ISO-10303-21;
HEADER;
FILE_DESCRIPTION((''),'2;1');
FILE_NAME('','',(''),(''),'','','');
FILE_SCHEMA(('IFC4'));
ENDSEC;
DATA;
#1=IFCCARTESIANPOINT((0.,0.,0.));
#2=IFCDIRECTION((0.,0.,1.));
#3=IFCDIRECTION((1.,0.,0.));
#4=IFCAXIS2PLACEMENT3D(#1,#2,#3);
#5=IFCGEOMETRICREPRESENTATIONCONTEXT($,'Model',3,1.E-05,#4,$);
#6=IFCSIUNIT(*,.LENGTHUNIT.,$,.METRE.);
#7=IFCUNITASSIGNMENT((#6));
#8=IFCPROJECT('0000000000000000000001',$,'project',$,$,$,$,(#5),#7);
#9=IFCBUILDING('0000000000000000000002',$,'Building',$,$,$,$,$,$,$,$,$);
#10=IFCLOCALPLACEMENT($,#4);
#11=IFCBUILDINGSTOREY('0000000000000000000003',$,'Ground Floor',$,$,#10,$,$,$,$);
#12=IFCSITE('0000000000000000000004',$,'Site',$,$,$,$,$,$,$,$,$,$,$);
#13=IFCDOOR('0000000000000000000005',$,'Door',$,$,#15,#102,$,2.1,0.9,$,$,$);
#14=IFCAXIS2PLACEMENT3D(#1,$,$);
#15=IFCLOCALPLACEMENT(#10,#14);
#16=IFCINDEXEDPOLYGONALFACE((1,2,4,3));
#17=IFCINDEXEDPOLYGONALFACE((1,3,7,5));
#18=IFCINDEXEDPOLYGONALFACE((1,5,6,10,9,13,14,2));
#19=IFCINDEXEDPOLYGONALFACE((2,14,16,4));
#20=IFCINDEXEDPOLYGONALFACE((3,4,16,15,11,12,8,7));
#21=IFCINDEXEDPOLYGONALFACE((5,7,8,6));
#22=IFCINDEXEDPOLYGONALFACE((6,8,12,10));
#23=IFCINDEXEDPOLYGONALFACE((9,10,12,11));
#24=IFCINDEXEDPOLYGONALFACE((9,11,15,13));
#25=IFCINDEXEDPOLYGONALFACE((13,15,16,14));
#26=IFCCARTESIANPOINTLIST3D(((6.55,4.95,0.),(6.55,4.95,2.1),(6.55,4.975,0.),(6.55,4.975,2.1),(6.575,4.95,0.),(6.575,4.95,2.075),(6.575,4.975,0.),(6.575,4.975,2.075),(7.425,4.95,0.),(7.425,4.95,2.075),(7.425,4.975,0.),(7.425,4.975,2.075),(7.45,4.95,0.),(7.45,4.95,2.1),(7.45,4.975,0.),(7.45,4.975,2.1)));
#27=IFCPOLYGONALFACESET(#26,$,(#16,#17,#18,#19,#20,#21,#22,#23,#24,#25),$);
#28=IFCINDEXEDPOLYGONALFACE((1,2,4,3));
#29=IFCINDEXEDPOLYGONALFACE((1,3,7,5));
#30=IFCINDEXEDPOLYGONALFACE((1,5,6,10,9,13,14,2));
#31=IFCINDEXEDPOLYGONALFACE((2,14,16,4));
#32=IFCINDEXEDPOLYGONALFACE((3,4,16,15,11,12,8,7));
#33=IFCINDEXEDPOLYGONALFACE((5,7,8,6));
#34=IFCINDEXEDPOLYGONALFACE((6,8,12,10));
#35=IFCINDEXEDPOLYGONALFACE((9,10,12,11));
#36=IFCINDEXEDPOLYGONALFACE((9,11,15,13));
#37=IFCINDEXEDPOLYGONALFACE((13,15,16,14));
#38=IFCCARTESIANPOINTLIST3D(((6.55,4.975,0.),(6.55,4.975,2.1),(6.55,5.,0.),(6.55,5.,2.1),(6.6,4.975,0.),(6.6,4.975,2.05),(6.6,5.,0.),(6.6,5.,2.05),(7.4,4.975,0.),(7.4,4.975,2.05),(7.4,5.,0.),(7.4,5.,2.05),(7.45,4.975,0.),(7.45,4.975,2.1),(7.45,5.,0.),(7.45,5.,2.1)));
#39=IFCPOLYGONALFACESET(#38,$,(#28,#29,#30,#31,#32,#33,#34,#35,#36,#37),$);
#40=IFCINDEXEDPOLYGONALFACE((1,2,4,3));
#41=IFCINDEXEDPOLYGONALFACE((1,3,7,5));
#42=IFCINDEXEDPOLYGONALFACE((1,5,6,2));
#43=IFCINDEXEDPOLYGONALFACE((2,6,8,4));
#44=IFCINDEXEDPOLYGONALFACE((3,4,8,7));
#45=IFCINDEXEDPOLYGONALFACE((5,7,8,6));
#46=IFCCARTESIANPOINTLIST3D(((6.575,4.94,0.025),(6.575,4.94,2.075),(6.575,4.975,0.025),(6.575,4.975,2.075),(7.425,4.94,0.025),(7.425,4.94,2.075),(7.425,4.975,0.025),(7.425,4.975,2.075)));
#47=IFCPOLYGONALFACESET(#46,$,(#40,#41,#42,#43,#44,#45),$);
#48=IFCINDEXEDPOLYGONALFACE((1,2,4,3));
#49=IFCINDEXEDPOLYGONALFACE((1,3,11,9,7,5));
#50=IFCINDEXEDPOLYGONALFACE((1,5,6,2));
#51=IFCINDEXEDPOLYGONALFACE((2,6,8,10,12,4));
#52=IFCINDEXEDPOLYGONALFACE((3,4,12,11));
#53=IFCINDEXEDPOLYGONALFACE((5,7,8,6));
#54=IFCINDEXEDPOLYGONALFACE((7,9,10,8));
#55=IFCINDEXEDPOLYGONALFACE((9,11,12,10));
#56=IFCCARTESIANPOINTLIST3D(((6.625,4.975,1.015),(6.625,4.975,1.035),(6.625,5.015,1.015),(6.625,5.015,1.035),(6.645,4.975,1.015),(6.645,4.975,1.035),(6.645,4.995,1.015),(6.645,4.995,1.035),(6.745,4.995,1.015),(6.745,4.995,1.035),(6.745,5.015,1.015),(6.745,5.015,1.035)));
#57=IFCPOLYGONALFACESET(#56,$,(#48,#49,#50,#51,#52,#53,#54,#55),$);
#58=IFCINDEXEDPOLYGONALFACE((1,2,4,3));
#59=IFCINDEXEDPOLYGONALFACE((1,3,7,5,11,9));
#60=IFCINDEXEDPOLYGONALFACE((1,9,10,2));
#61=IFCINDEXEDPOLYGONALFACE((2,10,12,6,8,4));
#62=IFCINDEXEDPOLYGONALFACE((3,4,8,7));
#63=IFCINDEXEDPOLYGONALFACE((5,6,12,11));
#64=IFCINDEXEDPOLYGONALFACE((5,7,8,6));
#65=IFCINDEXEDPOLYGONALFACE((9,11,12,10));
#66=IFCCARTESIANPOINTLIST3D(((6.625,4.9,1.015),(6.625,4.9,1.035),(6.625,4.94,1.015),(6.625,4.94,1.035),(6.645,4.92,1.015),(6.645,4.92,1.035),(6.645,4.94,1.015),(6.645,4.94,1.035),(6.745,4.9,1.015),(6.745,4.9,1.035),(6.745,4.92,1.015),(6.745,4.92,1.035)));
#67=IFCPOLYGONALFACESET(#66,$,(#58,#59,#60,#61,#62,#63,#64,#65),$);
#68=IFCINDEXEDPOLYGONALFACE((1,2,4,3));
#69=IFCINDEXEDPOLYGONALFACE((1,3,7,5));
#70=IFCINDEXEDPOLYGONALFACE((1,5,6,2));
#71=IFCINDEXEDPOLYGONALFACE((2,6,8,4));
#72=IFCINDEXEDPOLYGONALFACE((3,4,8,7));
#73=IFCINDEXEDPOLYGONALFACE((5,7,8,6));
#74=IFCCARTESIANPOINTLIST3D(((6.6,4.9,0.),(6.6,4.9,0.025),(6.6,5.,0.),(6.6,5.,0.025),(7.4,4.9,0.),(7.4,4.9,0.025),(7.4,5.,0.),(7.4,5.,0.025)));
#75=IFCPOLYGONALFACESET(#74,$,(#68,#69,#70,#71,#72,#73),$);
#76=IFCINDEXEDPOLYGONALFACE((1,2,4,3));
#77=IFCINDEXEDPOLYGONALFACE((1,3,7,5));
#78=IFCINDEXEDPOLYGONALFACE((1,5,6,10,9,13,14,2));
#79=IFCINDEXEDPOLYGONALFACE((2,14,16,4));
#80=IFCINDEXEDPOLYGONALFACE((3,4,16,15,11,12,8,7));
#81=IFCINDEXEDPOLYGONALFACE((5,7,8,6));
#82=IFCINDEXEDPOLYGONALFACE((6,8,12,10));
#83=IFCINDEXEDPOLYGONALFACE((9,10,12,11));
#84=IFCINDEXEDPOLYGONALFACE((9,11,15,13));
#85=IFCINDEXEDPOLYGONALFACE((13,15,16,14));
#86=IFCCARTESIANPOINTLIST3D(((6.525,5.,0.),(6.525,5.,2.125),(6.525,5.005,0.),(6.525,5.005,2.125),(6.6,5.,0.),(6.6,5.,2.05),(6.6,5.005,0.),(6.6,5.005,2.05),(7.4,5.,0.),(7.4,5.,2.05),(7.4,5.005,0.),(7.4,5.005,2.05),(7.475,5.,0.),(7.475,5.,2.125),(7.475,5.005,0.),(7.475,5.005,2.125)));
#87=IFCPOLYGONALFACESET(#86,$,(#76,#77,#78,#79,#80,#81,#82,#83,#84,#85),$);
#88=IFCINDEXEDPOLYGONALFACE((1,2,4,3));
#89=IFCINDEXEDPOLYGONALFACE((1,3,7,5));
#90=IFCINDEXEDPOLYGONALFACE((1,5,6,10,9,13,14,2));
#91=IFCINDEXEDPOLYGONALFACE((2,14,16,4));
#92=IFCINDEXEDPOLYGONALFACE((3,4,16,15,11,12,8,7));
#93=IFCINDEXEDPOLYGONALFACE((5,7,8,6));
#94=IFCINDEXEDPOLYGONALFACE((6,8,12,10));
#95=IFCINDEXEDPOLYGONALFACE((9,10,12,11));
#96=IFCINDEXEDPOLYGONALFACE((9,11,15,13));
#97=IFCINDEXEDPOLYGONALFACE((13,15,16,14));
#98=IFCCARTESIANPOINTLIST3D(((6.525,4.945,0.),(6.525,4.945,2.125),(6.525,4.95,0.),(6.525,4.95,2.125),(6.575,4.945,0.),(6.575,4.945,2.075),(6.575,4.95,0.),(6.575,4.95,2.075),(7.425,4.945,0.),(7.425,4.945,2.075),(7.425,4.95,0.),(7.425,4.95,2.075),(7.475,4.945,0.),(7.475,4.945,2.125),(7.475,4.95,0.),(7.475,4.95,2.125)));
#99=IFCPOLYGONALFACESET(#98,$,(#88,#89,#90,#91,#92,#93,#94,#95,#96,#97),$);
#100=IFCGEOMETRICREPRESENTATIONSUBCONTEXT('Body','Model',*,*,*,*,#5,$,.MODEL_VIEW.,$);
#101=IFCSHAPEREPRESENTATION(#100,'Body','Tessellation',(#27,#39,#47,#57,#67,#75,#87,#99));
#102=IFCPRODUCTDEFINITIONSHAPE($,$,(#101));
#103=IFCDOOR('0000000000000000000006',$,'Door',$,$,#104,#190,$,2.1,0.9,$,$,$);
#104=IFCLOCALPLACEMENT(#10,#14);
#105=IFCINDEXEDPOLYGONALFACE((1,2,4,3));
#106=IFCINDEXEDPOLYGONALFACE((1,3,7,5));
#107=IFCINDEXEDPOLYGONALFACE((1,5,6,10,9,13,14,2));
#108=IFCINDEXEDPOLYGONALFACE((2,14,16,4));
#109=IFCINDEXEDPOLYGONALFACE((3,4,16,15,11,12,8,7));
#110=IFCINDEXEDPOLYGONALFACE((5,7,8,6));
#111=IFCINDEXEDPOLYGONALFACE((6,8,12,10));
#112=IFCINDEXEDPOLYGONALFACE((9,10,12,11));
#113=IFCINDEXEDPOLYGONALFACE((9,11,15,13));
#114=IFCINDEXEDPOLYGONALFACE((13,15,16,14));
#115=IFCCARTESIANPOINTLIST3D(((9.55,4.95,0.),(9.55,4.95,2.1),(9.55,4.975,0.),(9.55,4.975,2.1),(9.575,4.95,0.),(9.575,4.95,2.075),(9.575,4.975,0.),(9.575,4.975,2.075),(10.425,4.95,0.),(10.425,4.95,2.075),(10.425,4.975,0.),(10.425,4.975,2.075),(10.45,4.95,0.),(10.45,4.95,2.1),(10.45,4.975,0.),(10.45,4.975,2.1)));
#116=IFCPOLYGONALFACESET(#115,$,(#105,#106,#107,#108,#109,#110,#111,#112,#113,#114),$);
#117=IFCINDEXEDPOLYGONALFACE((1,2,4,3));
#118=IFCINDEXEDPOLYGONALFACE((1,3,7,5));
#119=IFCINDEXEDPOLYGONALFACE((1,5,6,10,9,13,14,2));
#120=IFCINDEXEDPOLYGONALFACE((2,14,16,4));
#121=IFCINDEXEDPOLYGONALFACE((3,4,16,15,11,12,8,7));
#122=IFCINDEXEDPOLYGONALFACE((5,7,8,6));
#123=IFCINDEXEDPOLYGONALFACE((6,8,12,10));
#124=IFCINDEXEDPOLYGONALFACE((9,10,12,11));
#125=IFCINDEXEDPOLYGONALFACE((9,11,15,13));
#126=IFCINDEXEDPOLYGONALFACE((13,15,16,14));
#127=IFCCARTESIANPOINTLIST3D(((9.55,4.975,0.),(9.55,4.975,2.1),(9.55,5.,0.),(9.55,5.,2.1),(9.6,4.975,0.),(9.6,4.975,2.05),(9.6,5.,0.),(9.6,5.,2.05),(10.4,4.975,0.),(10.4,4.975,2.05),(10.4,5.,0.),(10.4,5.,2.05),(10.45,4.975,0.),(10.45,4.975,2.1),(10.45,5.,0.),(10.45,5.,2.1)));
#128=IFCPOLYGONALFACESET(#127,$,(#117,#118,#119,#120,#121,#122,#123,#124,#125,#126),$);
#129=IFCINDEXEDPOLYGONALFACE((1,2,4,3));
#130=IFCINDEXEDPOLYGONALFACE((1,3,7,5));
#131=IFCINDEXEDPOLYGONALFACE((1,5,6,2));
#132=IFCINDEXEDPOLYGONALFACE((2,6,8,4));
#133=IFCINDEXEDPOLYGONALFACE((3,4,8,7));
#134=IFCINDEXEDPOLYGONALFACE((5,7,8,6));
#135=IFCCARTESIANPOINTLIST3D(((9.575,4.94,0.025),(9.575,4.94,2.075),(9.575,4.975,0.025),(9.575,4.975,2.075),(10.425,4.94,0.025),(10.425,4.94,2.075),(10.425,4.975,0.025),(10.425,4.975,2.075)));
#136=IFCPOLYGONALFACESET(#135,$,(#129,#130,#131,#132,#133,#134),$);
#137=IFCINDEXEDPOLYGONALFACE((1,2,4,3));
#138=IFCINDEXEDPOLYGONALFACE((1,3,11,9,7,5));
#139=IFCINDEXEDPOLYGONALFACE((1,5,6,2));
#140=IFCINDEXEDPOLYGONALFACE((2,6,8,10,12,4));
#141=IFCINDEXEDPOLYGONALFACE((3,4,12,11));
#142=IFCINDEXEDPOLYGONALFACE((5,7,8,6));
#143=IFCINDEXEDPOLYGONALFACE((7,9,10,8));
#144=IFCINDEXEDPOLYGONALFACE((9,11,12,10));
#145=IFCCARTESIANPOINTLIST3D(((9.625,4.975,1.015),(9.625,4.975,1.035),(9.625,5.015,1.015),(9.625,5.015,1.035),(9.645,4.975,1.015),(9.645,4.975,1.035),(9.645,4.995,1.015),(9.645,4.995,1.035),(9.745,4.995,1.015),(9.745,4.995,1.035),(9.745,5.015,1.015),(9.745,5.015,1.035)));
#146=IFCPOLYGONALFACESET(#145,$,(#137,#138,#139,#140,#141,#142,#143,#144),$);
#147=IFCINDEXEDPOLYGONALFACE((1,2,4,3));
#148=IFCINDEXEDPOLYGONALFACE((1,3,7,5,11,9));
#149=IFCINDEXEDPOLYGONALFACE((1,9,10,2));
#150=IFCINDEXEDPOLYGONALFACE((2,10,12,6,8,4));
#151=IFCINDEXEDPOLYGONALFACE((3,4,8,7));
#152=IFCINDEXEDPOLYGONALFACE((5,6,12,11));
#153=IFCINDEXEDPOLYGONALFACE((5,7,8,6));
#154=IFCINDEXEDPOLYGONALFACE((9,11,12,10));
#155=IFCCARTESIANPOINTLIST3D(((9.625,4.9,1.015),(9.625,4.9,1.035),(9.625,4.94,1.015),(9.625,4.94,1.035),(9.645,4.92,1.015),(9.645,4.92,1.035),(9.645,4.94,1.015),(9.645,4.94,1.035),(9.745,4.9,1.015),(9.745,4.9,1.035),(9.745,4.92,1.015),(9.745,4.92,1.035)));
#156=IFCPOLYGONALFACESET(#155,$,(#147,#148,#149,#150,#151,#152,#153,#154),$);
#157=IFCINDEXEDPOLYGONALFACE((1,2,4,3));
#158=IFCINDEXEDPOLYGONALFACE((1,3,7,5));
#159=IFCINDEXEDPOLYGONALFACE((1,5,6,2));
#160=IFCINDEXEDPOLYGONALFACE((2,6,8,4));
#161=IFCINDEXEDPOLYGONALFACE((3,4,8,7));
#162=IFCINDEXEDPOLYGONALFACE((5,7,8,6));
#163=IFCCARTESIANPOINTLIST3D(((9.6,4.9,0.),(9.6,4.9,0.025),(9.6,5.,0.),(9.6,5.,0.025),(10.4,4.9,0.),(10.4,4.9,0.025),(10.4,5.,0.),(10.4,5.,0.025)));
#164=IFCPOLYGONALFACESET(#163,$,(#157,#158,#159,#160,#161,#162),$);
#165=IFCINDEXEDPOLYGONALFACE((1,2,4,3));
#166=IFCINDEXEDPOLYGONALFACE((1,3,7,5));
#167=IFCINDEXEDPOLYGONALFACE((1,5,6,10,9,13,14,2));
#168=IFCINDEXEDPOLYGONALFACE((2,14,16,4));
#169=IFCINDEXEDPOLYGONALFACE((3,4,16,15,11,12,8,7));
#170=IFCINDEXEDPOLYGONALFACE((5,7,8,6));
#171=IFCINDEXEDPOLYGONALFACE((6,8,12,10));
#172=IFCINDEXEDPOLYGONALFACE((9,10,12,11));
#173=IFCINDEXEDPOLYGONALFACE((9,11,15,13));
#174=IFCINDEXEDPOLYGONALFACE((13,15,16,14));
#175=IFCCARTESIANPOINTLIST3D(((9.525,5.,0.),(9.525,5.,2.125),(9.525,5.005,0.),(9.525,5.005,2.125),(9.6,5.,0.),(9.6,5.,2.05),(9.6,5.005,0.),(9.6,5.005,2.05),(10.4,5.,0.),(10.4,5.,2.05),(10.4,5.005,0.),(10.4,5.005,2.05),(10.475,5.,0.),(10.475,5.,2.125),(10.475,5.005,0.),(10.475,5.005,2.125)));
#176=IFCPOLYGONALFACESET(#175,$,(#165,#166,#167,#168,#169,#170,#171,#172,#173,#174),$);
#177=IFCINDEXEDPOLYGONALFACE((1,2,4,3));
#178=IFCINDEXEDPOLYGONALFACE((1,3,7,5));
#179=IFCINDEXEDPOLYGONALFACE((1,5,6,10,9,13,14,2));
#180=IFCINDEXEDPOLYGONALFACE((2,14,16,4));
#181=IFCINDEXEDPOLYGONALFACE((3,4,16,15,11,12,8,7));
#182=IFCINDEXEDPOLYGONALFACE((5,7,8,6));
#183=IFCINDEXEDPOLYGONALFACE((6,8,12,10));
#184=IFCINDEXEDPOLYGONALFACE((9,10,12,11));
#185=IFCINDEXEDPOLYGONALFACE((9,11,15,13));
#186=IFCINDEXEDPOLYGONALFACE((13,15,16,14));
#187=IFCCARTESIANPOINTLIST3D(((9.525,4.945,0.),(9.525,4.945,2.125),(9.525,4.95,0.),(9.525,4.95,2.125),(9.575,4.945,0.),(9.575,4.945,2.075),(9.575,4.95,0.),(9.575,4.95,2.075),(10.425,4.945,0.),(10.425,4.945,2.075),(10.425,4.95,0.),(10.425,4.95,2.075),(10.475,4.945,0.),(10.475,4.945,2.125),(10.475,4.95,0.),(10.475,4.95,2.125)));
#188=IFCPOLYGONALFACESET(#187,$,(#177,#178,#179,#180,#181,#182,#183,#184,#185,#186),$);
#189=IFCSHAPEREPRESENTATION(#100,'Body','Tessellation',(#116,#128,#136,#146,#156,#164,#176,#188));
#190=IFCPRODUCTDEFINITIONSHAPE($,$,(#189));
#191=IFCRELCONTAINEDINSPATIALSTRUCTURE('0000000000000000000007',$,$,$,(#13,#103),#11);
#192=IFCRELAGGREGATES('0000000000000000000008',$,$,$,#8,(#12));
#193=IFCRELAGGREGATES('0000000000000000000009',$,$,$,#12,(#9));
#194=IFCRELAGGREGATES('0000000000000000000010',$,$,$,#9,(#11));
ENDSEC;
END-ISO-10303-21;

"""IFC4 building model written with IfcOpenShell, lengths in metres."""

from ifc_helpers import new_model, si_unit, frame, origin_with_axes, place, context, subcontext, project, spatial, line, indexed_curve, outline, extrude, element, save


model = new_model("IFC4")

# Units and contexts
model_context = context("Model", 3, precision=1e-05, world=origin_with_axes())
body_context = subcontext(model_context, "Body", "Model", "MODEL_VIEW")
ifc_project = project(units=[si_unit("LENGTHUNIT", "METRE")], contexts=[model_context])

# Site, building, storey
site = spatial("IfcSite", under=ifc_project, Name="Site")
building = spatial("IfcBuilding", under=site, Name="Building")
storey_placement = place(None, origin_with_axes())
storey = spatial("IfcBuildingStorey", under=building, at=storey_placement, Name="Ground Floor")

# Doors
door_1_placement = place(storey_placement, frame((7.45, 5.0, 0.0), z_axis=(0.0, 0.0, 1.0), x_axis=(-1.0, 0.0, 0.0)))
element("IfcDoor", 1, at=door_1_placement, inside=storey, Name="Door", OverallHeight=2.1, OverallWidth=0.9, context=body_context, shape_type="SweptSolid", body=[
    extrude(outline(indexed_curve([(0.0, 0.0), (0.0, 2.1), (0.9, 2.1), (0.9, 0.0), (0.875, 0.0), (0.875, 2.075), (0.025, 2.075), (0.025, 0.0)], segments=[line(1, 2, 3, 4, 5, 6, 7, 8, 1)])), frame((0.0, 0.025, 0.0), z_axis=(0.0, -1.0, 0.0), x_axis=(1.0, 0.0, 0.0)), (0.0, 0.0, -1.0), 0.025),
    extrude(outline(indexed_curve([(0.0, 0.0), (0.0, 2.1), (0.9, 2.1), (0.9, 0.0), (0.85, 0.0), (0.85, 2.05), (0.05, 2.05), (0.05, 0.0)], segments=[line(1, 2, 3, 4, 5, 6, 7, 8, 1)])), frame((0.0, 0.0, 0.0), z_axis=(0.0, -1.0, 0.0), x_axis=(1.0, 0.0, 0.0)), (0.0, 0.0, -1.0), 0.025),
    extrude(outline(indexed_curve([(0.0, 0.0), (0.85, 0.0), (0.85, 0.035), (0.0, 0.035)], segments=[line(1, 2, 3, 4, 1)])), frame((0.025, 0.025, 0.025), z_axis=(0.0, 0.0, 1.0), x_axis=(1.0, 0.0, 0.0)), (0.0, 0.0, 1.0), 2.05),
    extrude(outline(indexed_curve([(0.0, 0.0), (0.0, -0.04), (-0.12, -0.04), (-0.12, -0.02), (-0.02, -0.02), (-0.02, 0.0)], segments=[line(1, 2, 3, 4, 5, 6, 1)])), frame((0.825, 0.025, 1.015), z_axis=(0.0, 0.0, 1.0), x_axis=(1.0, 0.0, 0.0)), (0.0, 0.0, 1.0), 0.02),
    extrude(outline(indexed_curve([(0.0, 0.0), (0.0, 0.04), (-0.12, 0.04), (-0.12, 0.02), (-0.02, 0.02), (-0.02, 0.0)], segments=[line(1, 2, 3, 4, 5, 6, 1)])), frame((0.825, 0.06, 1.015), z_axis=(0.0, 0.0, 1.0), x_axis=(1.0, 0.0, 0.0)), (0.0, 0.0, 1.0), 0.02),
    extrude(outline(indexed_curve([(0.0, 0.0), (0.8, 0.0), (0.8, 0.1), (0.0, 0.1)], segments=[line(1, 2, 3, 4, 1)])), frame((0.05, 0.0, 0.0), z_axis=(0.0, 0.0, 1.0), x_axis=(1.0, 0.0, 0.0)), (0.0, 0.0, 1.0), 0.025),
    extrude(outline(indexed_curve([(0.0, 0.0), (0.0, 2.125), (0.95, 2.125), (0.95, 0.0), (0.875, 0.0), (0.875, 2.05), (0.075, 2.05), (0.075, 0.0)], segments=[line(1, 2, 3, 4, 5, 6, 7, 8, 1)])), frame((-0.025, -0.005, 0.0), z_axis=(0.0, -1.0, 0.0), x_axis=(1.0, 0.0, 0.0)), (0.0, 0.0, -1.0), 0.005),
    extrude(outline(indexed_curve([(0.0, 0.0), (0.0, 2.125), (0.95, 2.125), (0.95, 0.0), (0.9, 0.0), (0.9, 2.075), (0.05, 2.075), (0.05, 0.0)], segments=[line(1, 2, 3, 4, 5, 6, 7, 8, 1)])), frame((-0.025, 0.05, 0.0), z_axis=(0.0, -1.0, 0.0), x_axis=(1.0, 0.0, 0.0)), (0.0, 0.0, -1.0), 0.005),
])
door_2_placement = place(storey_placement, frame((10.45, 5.0, 0.0), z_axis=(0.0, 0.0, 1.0), x_axis=(-1.0, 0.0, 0.0)))
element("IfcDoor", 2, at=door_2_placement, inside=storey, Name="Door", OverallHeight=2.1, OverallWidth=0.9, context=body_context, shape_type="SweptSolid", body=[
    extrude(outline(indexed_curve([(0.0, 0.0), (0.0, 2.1), (0.9, 2.1), (0.9, 0.0), (0.875, 0.0), (0.875, 2.075), (0.025, 2.075), (0.025, 0.0)], segments=[line(1, 2, 3, 4, 5, 6, 7, 8, 1)])), frame((0.0, 0.025, 0.0), z_axis=(0.0, -1.0, 0.0), x_axis=(1.0, 0.0, 0.0)), (0.0, 0.0, -1.0), 0.025),
    extrude(outline(indexed_curve([(0.0, 0.0), (0.0, 2.1), (0.9, 2.1), (0.9, 0.0), (0.85, 0.0), (0.85, 2.05), (0.05, 2.05), (0.05, 0.0)], segments=[line(1, 2, 3, 4, 5, 6, 7, 8, 1)])), frame((0.0, 0.0, 0.0), z_axis=(0.0, -1.0, 0.0), x_axis=(1.0, 0.0, 0.0)), (0.0, 0.0, -1.0), 0.025),
    extrude(outline(indexed_curve([(0.0, 0.0), (0.85, 0.0), (0.85, 0.035), (0.0, 0.035)], segments=[line(1, 2, 3, 4, 1)])), frame((0.025, 0.025, 0.025), z_axis=(0.0, 0.0, 1.0), x_axis=(1.0, 0.0, 0.0)), (0.0, 0.0, 1.0), 2.05),
    extrude(outline(indexed_curve([(0.0, 0.0), (0.0, -0.04), (-0.12, -0.04), (-0.12, -0.02), (-0.02, -0.02), (-0.02, 0.0)], segments=[line(1, 2, 3, 4, 5, 6, 1)])), frame((0.825, 0.025, 1.015), z_axis=(0.0, 0.0, 1.0), x_axis=(1.0, 0.0, 0.0)), (0.0, 0.0, 1.0), 0.02),
    extrude(outline(indexed_curve([(0.0, 0.0), (0.0, 0.04), (-0.12, 0.04), (-0.12, 0.02), (-0.02, 0.02), (-0.02, 0.0)], segments=[line(1, 2, 3, 4, 5, 6, 1)])), frame((0.825, 0.06, 1.015), z_axis=(0.0, 0.0, 1.0), x_axis=(1.0, 0.0, 0.0)), (0.0, 0.0, 1.0), 0.02),
    extrude(outline(indexed_curve([(0.0, 0.0), (0.8, 0.0), (0.8, 0.1), (0.0, 0.1)], segments=[line(1, 2, 3, 4, 1)])), frame((0.05, 0.0, 0.0), z_axis=(0.0, 0.0, 1.0), x_axis=(1.0, 0.0, 0.0)), (0.0, 0.0, 1.0), 0.025),
    extrude(outline(indexed_curve([(0.0, 0.0), (0.0, 2.125), (0.95, 2.125), (0.95, 0.0), (0.875, 0.0), (0.875, 2.05), (0.075, 2.05), (0.075, 0.0)], segments=[line(1, 2, 3, 4, 5, 6, 7, 8, 1)])), frame((-0.025, -0.005, 0.0), z_axis=(0.0, -1.0, 0.0), x_axis=(1.0, 0.0, 0.0)), (0.0, 0.0, -1.0), 0.005),
    extrude(outline(indexed_curve([(0.0, 0.0), (0.0, 2.125), (0.95, 2.125), (0.95, 0.0), (0.9, 0.0), (0.9, 2.075), (0.05, 2.075), (0.05, 0.0)], segments=[line(1, 2, 3, 4, 5, 6, 7, 8, 1)])), frame((-0.025, 0.05, 0.0), z_axis=(0.0, -1.0, 0.0), x_axis=(1.0, 0.0, 0.0)), (0.0, 0.0, -1.0), 0.005),
])

save(model, "model.ifc")
